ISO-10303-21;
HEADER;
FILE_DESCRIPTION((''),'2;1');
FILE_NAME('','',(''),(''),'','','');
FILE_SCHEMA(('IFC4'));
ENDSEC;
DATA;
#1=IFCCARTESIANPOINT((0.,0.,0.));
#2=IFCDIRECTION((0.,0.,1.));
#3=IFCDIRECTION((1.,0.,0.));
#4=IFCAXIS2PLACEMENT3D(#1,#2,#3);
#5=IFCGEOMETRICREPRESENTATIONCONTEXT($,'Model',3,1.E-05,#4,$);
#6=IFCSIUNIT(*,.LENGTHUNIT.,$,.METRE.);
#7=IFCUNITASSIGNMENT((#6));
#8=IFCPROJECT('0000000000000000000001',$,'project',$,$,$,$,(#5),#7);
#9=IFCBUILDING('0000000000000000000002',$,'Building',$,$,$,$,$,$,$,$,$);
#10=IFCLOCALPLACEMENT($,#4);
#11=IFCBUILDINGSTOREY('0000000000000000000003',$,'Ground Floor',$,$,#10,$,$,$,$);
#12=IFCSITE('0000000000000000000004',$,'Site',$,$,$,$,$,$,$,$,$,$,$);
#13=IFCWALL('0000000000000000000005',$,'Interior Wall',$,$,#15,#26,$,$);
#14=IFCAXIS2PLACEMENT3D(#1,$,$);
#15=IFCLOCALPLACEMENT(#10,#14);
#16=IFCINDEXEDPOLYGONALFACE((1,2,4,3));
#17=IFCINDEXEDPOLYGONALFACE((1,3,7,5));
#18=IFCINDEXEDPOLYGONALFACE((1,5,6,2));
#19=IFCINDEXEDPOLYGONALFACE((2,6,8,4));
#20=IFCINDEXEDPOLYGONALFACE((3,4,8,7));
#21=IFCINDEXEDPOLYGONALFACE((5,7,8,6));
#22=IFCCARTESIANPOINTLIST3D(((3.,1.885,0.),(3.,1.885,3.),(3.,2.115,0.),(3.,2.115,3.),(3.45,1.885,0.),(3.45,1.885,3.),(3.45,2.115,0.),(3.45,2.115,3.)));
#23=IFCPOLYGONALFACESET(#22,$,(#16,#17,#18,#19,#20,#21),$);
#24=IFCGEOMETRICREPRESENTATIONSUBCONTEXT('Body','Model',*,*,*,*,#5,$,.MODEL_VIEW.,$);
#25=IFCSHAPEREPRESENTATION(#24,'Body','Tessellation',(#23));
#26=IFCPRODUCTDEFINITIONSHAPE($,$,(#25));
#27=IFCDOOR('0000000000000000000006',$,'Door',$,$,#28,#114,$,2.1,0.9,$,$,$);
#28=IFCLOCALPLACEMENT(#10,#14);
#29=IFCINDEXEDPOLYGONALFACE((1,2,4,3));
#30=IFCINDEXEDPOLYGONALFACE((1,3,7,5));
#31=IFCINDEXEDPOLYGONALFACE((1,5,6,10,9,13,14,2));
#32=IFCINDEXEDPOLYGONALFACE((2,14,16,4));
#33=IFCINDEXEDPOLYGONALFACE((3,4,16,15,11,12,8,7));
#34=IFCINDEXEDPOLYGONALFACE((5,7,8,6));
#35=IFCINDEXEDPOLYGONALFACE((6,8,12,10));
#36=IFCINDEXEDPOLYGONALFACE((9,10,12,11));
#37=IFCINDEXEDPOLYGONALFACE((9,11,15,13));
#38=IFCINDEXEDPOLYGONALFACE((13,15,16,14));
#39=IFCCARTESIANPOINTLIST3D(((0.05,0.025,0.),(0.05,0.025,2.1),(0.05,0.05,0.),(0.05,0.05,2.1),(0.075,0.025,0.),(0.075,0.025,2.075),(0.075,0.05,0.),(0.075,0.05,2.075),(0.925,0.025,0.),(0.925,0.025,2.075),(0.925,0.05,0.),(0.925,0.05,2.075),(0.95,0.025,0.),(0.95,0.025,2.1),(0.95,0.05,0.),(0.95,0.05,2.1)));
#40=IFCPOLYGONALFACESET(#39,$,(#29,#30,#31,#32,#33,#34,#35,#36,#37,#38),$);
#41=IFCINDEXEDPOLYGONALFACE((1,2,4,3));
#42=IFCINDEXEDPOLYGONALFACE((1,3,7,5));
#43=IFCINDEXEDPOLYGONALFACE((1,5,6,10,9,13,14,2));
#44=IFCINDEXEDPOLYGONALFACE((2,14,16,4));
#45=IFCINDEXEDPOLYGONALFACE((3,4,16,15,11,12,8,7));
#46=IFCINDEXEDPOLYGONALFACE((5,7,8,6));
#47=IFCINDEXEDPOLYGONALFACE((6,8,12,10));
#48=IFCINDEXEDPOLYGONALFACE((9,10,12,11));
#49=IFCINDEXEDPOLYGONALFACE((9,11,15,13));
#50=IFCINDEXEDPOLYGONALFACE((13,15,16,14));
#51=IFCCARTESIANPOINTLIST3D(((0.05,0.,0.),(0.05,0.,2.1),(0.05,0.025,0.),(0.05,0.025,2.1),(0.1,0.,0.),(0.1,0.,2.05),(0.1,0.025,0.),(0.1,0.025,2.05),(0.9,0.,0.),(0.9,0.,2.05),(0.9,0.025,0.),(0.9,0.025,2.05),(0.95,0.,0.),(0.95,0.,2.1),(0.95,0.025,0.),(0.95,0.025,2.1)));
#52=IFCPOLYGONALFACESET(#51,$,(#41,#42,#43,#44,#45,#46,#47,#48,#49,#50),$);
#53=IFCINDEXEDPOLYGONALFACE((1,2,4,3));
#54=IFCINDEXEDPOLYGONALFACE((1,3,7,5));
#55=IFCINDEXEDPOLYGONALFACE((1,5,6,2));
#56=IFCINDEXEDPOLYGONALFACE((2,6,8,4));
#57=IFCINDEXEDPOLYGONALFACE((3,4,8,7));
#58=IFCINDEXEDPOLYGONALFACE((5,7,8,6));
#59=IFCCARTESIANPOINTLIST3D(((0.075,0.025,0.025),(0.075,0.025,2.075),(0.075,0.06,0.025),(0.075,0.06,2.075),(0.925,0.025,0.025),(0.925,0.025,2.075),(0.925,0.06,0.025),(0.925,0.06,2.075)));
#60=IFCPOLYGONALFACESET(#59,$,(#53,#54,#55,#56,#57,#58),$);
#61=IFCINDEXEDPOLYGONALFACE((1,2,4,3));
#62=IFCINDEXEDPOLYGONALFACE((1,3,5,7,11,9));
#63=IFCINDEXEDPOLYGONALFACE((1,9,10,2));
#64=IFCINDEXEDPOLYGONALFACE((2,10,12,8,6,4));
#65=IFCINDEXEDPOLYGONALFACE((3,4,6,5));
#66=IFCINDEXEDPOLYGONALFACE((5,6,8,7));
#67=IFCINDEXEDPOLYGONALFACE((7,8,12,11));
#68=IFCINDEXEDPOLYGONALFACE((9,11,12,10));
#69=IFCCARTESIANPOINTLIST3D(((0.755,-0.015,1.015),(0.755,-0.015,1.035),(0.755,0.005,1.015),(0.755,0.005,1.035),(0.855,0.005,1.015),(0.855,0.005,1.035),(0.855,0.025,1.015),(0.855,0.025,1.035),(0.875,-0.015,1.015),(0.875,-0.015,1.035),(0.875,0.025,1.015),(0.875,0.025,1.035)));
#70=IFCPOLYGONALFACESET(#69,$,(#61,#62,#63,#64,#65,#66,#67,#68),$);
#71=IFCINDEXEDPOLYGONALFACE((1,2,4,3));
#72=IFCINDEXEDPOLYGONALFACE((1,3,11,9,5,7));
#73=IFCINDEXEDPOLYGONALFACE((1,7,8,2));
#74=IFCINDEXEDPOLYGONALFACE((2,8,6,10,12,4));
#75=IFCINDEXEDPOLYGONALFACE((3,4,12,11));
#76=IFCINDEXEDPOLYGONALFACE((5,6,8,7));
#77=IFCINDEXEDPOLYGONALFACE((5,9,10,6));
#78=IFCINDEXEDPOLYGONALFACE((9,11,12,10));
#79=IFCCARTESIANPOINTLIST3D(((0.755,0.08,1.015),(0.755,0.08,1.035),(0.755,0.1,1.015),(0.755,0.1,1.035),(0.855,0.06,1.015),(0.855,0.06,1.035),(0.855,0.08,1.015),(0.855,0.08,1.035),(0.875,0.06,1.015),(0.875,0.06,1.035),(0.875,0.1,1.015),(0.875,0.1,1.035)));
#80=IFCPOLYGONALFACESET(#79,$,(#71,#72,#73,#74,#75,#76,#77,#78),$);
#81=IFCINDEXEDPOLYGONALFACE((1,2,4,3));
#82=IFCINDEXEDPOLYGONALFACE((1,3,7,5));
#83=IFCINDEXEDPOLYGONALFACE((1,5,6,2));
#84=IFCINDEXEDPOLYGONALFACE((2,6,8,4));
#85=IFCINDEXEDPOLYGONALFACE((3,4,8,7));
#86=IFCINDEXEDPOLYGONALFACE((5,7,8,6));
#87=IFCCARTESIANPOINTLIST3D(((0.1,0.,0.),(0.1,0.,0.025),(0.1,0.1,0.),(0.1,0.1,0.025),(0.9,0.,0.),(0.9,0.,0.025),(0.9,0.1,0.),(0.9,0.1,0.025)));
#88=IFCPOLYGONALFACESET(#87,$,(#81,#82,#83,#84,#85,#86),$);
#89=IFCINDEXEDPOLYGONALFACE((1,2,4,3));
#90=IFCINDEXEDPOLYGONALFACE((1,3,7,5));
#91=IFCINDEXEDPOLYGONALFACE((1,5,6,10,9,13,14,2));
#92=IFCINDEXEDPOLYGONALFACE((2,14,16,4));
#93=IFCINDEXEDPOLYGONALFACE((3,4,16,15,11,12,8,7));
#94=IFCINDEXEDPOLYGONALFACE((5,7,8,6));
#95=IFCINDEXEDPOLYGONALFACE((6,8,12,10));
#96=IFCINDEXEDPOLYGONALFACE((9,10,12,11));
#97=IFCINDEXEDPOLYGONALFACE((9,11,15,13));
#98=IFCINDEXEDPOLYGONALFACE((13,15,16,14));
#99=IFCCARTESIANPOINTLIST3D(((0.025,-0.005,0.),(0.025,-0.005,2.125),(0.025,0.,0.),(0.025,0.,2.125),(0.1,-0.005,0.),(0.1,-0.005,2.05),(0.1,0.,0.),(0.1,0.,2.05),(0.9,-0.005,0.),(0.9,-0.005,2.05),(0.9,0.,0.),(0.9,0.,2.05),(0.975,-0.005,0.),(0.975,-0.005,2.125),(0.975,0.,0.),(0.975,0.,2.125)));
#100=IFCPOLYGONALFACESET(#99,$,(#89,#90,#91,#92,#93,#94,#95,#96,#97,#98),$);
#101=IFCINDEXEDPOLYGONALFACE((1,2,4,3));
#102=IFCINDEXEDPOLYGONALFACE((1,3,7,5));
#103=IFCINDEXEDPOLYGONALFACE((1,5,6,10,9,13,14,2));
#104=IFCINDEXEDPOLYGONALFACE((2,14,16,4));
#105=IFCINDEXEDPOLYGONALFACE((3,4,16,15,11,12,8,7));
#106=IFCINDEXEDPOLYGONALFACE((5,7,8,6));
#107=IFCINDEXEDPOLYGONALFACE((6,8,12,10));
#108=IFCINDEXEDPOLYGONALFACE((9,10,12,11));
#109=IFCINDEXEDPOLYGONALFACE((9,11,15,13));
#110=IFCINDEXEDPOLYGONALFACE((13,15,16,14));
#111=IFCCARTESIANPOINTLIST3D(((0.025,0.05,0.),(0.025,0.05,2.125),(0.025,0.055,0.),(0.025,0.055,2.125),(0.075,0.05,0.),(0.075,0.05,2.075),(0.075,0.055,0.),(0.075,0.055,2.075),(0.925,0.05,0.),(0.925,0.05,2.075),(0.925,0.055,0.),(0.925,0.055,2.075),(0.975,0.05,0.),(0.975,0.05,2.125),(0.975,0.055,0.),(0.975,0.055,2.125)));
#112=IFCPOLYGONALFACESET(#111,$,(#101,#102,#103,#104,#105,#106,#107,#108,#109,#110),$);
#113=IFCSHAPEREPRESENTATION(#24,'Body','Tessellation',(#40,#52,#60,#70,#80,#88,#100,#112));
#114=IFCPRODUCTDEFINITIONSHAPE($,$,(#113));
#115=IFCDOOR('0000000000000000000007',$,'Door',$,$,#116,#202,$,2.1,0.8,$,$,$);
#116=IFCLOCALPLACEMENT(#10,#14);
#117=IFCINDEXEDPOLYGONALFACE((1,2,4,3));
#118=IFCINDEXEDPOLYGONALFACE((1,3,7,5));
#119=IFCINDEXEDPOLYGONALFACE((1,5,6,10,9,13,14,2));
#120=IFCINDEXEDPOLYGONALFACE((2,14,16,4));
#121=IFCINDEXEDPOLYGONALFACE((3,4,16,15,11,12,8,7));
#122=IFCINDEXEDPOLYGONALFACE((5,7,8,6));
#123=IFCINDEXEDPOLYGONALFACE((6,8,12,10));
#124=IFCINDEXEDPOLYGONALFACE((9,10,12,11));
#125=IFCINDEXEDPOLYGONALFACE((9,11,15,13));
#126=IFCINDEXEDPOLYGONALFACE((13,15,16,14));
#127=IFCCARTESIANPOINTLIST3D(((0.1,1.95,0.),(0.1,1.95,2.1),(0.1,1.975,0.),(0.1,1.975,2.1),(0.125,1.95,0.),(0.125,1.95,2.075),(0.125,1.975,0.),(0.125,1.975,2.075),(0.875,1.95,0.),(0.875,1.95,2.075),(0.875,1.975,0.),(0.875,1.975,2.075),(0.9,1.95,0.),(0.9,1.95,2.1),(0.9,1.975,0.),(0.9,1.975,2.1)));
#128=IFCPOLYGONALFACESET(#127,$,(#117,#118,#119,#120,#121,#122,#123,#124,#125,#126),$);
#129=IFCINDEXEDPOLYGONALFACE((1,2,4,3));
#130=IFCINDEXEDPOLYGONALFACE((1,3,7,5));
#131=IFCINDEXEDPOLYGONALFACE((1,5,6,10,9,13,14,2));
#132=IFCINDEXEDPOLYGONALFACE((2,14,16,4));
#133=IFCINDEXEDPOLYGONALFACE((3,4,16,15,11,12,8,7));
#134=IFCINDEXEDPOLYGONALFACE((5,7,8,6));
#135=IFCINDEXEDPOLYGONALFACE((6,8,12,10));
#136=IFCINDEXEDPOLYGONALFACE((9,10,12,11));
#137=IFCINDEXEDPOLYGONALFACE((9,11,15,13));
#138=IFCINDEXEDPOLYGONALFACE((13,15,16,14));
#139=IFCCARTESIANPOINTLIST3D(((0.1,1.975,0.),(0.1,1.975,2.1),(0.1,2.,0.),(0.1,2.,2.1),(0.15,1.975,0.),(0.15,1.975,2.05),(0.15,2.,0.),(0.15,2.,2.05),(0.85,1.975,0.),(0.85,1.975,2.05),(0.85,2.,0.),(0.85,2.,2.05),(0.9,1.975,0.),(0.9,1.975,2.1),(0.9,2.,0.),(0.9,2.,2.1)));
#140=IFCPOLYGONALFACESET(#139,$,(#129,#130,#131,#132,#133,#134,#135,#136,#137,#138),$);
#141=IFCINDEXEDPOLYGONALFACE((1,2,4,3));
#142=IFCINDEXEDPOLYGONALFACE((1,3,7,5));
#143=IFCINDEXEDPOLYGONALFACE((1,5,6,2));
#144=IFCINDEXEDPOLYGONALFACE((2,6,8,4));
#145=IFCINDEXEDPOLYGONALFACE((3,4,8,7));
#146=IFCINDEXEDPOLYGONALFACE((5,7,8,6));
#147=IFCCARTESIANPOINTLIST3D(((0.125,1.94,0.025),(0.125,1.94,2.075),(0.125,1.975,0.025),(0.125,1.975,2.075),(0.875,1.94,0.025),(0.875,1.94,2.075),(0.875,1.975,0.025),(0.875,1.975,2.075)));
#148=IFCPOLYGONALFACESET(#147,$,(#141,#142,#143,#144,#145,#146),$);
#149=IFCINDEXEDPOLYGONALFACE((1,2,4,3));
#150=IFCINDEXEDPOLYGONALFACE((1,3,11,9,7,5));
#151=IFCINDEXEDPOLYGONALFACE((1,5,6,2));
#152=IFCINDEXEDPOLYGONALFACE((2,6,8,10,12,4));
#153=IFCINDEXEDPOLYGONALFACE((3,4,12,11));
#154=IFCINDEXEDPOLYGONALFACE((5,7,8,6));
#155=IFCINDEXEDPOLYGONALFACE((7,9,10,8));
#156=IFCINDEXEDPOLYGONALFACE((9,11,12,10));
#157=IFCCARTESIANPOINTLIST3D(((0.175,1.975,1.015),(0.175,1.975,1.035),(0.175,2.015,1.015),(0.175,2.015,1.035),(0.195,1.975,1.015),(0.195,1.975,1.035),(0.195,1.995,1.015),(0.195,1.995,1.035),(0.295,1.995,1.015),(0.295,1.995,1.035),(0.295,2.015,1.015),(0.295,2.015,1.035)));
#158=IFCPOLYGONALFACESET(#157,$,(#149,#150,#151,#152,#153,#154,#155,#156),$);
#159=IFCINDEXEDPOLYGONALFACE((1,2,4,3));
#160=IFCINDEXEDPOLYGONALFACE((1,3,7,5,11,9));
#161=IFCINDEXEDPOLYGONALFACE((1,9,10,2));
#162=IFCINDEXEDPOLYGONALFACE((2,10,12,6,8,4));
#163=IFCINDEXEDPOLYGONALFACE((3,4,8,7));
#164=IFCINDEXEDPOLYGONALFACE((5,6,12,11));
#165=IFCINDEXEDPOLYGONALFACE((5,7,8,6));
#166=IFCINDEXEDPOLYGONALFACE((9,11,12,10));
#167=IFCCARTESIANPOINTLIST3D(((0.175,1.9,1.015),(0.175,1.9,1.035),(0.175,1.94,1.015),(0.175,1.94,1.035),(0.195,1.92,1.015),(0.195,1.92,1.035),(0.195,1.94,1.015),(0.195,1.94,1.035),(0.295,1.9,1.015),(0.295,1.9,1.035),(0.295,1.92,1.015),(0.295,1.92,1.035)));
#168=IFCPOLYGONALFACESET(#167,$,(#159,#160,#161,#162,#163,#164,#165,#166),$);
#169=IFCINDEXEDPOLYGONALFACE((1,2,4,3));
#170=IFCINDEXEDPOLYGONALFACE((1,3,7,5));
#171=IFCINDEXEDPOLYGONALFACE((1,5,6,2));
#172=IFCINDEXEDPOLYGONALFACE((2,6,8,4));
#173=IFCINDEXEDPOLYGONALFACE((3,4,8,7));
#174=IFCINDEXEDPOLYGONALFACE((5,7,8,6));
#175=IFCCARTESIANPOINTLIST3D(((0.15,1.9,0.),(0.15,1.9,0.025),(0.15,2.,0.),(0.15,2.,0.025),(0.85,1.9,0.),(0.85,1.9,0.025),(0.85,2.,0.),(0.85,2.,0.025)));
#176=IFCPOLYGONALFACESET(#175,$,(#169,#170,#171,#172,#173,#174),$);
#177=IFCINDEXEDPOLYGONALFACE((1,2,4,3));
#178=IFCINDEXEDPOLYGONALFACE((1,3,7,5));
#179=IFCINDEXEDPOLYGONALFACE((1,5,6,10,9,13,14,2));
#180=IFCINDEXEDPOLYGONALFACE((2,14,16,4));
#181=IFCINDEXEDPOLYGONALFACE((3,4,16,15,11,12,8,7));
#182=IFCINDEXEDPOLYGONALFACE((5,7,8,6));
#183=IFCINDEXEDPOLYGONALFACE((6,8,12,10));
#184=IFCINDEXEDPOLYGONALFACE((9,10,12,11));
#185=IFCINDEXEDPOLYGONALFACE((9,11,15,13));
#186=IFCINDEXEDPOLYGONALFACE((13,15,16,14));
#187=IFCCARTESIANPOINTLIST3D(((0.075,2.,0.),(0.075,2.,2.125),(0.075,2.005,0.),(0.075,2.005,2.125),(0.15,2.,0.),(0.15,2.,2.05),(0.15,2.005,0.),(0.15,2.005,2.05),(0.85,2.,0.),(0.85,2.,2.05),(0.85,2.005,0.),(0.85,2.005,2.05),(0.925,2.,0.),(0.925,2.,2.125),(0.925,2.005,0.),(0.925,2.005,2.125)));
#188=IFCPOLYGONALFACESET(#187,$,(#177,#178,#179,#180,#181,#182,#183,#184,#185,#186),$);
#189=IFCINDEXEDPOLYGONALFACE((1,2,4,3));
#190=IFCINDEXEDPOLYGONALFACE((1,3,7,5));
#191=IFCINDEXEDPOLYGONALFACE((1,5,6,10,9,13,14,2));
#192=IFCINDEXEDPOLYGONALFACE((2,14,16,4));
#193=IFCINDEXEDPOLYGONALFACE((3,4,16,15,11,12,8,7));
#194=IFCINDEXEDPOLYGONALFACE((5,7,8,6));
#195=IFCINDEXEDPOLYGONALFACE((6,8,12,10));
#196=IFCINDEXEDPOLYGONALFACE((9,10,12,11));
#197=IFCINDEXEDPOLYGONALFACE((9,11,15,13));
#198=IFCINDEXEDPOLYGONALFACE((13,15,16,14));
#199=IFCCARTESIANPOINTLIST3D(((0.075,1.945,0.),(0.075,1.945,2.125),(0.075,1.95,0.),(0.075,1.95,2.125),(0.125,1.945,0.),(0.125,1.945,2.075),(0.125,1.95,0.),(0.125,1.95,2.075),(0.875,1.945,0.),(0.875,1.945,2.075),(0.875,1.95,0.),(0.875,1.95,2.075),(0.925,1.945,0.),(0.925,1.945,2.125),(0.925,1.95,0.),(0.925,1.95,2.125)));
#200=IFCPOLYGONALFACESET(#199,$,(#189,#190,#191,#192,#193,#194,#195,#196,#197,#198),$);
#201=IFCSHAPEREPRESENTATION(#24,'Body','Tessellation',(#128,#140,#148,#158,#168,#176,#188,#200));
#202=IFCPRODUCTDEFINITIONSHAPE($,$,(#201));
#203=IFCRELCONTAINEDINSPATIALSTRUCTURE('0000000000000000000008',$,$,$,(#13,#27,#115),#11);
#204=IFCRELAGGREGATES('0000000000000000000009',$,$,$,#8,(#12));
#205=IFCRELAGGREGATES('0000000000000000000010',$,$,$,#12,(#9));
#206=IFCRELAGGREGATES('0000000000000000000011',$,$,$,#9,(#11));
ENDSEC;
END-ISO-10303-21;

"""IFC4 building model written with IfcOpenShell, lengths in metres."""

from ifc_helpers import new_model, si_unit, frame, origin_with_axes, place, context, subcontext, project, spatial, line, indexed_curve, outline, extrude, element, save


model = new_model("IFC4")

# Units and contexts
model_context = context("Model", 3, precision=1e-05, world=origin_with_axes())
body_context = subcontext(model_context, "Body", "Model", "MODEL_VIEW")
ifc_project = project(units=[si_unit("LENGTHUNIT", "METRE")], contexts=[model_context])

# Site, building, storey
site = spatial("IfcSite", under=ifc_project, Name="Site")
building = spatial("IfcBuilding", under=site, Name="Building")
storey_placement = place(None, origin_with_axes())
storey = spatial("IfcBuildingStorey", under=building, at=storey_placement, Name="Ground Floor")

# Wall
for number, where, z_axis, x_axis, name in (
    (1, (3.45, 2.0, 0.0), (0.0, 0.0, 1.0), (-1.0, 0.0, 0.0), "Interior Wall"),
):
    element("IfcWall", number, at=place(storey_placement, frame(where, z_axis=z_axis, x_axis=x_axis)), inside=storey, Name=name, context=body_context, shape_type="SweptSolid", body=[
        extrude(outline(indexed_curve([(0.0, 0.0), (0.0, 0.23), (0.45, 0.23), (0.45, 0.0), (0.0, 0.0)], self_intersect=False)), frame((0.0, -0.115, 0.0), z_axis=(0.0, 0.0, 1.0), x_axis=(1.0, 0.0, 0.0)), (0.0, 0.0, 1.0), 3.0),
    ])

# Doors
door_1_placement = place(storey_placement, frame((0.05, 0.0, 0.0), z_axis=(0.0, 0.0, 1.0), x_axis=(1.0, 0.0, 0.0)))
element("IfcDoor", 2, at=door_1_placement, inside=storey, Name="Door", OverallHeight=2.1, OverallWidth=0.9, context=body_context, shape_type="SweptSolid", body=[
    extrude(outline(indexed_curve([(0.0, 0.0), (0.0, 2.1), (0.9, 2.1), (0.9, 0.0), (0.875, 0.0), (0.875, 2.075), (0.025, 2.075), (0.025, 0.0)], segments=[line(1, 2, 3, 4, 5, 6, 7, 8, 1)])), frame((0.0, 0.025, 0.0), z_axis=(0.0, -1.0, 0.0), x_axis=(1.0, 0.0, 0.0)), (0.0, 0.0, -1.0), 0.025),
    extrude(outline(indexed_curve([(0.0, 0.0), (0.0, 2.1), (0.9, 2.1), (0.9, 0.0), (0.85, 0.0), (0.85, 2.05), (0.05, 2.05), (0.05, 0.0)], segments=[line(1, 2, 3, 4, 5, 6, 7, 8, 1)])), frame((0.0, 0.0, 0.0), z_axis=(0.0, -1.0, 0.0), x_axis=(1.0, 0.0, 0.0)), (0.0, 0.0, -1.0), 0.025),
    extrude(outline(indexed_curve([(0.0, 0.0), (0.85, 0.0), (0.85, 0.035), (0.0, 0.035)], segments=[line(1, 2, 3, 4, 1)])), frame((0.025, 0.025, 0.025), z_axis=(0.0, 0.0, 1.0), x_axis=(1.0, 0.0, 0.0)), (0.0, 0.0, 1.0), 2.05),
    extrude(outline(indexed_curve([(0.0, 0.0), (0.0, -0.04), (-0.12, -0.04), (-0.12, -0.02), (-0.02, -0.02), (-0.02, 0.0)], segments=[line(1, 2, 3, 4, 5, 6, 1)])), frame((0.825, 0.025, 1.015), z_axis=(0.0, 0.0, 1.0), x_axis=(1.0, 0.0, 0.0)), (0.0, 0.0, 1.0), 0.02),
    extrude(outline(indexed_curve([(0.0, 0.0), (0.0, 0.04), (-0.12, 0.04), (-0.12, 0.02), (-0.02, 0.02), (-0.02, 0.0)], segments=[line(1, 2, 3, 4, 5, 6, 1)])), frame((0.825, 0.06, 1.015), z_axis=(0.0, 0.0, 1.0), x_axis=(1.0, 0.0, 0.0)), (0.0, 0.0, 1.0), 0.02),
    extrude(outline(indexed_curve([(0.0, 0.0), (0.8, 0.0), (0.8, 0.1), (0.0, 0.1)], segments=[line(1, 2, 3, 4, 1)])), frame((0.05, 0.0, 0.0), z_axis=(0.0, 0.0, 1.0), x_axis=(1.0, 0.0, 0.0)), (0.0, 0.0, 1.0), 0.025),
    extrude(outline(indexed_curve([(0.0, 0.0), (0.0, 2.125), (0.95, 2.125), (0.95, 0.0), (0.875, 0.0), (0.875, 2.05), (0.075, 2.05), (0.075, 0.0)], segments=[line(1, 2, 3, 4, 5, 6, 7, 8, 1)])), frame((-0.025, -0.005, 0.0), z_axis=(0.0, -1.0, 0.0), x_axis=(1.0, 0.0, 0.0)), (0.0, 0.0, -1.0), 0.005),
    extrude(outline(indexed_curve([(0.0, 0.0), (0.0, 2.125), (0.95, 2.125), (0.95, 0.0), (0.9, 0.0), (0.9, 2.075), (0.05, 2.075), (0.05, 0.0)], segments=[line(1, 2, 3, 4, 5, 6, 7, 8, 1)])), frame((-0.025, 0.05, 0.0), z_axis=(0.0, -1.0, 0.0), x_axis=(1.0, 0.0, 0.0)), (0.0, 0.0, -1.0), 0.005),
])
door_2_placement = place(storey_placement, frame((0.9, 2.0, 0.0), z_axis=(0.0, 0.0, 1.0), x_axis=(-1.0, 0.0, 0.0)))
element("IfcDoor", 3, at=door_2_placement, inside=storey, Name="Door", OverallHeight=2.1, OverallWidth=0.8, context=body_context, shape_type="SweptSolid", body=[
    extrude(outline(indexed_curve([(0.0, 0.0), (0.0, 2.1), (0.8, 2.1), (0.8, 0.0), (0.775, 0.0), (0.775, 2.075), (0.025, 2.075), (0.025, 0.0)], segments=[line(1, 2, 3, 4, 5, 6, 7, 8, 1)])), frame((0.0, 0.025, 0.0), z_axis=(0.0, -1.0, 0.0), x_axis=(1.0, 0.0, 0.0)), (0.0, 0.0, -1.0), 0.025),
    extrude(outline(indexed_curve([(0.0, 0.0), (0.0, 2.1), (0.8, 2.1), (0.8, 0.0), (0.75, 0.0), (0.75, 2.05), (0.05, 2.05), (0.05, 0.0)], segments=[line(1, 2, 3, 4, 5, 6, 7, 8, 1)])), frame((0.0, 0.0, 0.0), z_axis=(0.0, -1.0, 0.0), x_axis=(1.0, 0.0, 0.0)), (0.0, 0.0, -1.0), 0.025),
    extrude(outline(indexed_curve([(0.0, 0.0), (0.75, 0.0), (0.75, 0.035), (0.0, 0.035)], segments=[line(1, 2, 3, 4, 1)])), frame((0.025, 0.025, 0.025), z_axis=(0.0, 0.0, 1.0), x_axis=(1.0, 0.0, 0.0)), (0.0, 0.0, 1.0), 2.05),
    extrude(outline(indexed_curve([(0.0, 0.0), (0.0, -0.04), (-0.12, -0.04), (-0.12, -0.02), (-0.02, -0.02), (-0.02, 0.0)], segments=[line(1, 2, 3, 4, 5, 6, 1)])), frame((0.725, 0.025, 1.015), z_axis=(0.0, 0.0, 1.0), x_axis=(1.0, 0.0, 0.0)), (0.0, 0.0, 1.0), 0.02),
    extrude(outline(indexed_curve([(0.0, 0.0), (0.0, 0.04), (-0.12, 0.04), (-0.12, 0.02), (-0.02, 0.02), (-0.02, 0.0)], segments=[line(1, 2, 3, 4, 5, 6, 1)])), frame((0.725, 0.06, 1.015), z_axis=(0.0, 0.0, 1.0), x_axis=(1.0, 0.0, 0.0)), (0.0, 0.0, 1.0), 0.02),
    extrude(outline(indexed_curve([(0.0, 0.0), (0.7, 0.0), (0.7, 0.1), (0.0, 0.1)], segments=[line(1, 2, 3, 4, 1)])), frame((0.05, 0.0, 0.0), z_axis=(0.0, 0.0, 1.0), x_axis=(1.0, 0.0, 0.0)), (0.0, 0.0, 1.0), 0.025),
    extrude(outline(indexed_curve([(0.0, 0.0), (0.0, 2.125), (0.85, 2.125), (0.85, 0.0), (0.775, 0.0), (0.775, 2.05), (0.075, 2.05), (0.075, 0.0)], segments=[line(1, 2, 3, 4, 5, 6, 7, 8, 1)])), frame((-0.025, -0.005, 0.0), z_axis=(0.0, -1.0, 0.0), x_axis=(1.0, 0.0, 0.0)), (0.0, 0.0, -1.0), 0.005),
    extrude(outline(indexed_curve([(0.0, 0.0), (0.0, 2.125), (0.85, 2.125), (0.85, 0.0), (0.8, 0.0), (0.8, 2.075), (0.05, 2.075), (0.05, 0.0)], segments=[line(1, 2, 3, 4, 5, 6, 7, 8, 1)])), frame((-0.025, 0.05, 0.0), z_axis=(0.0, -1.0, 0.0), x_axis=(1.0, 0.0, 0.0)), (0.0, 0.0, -1.0), 0.005),
])

save(model, "model.ifc")
